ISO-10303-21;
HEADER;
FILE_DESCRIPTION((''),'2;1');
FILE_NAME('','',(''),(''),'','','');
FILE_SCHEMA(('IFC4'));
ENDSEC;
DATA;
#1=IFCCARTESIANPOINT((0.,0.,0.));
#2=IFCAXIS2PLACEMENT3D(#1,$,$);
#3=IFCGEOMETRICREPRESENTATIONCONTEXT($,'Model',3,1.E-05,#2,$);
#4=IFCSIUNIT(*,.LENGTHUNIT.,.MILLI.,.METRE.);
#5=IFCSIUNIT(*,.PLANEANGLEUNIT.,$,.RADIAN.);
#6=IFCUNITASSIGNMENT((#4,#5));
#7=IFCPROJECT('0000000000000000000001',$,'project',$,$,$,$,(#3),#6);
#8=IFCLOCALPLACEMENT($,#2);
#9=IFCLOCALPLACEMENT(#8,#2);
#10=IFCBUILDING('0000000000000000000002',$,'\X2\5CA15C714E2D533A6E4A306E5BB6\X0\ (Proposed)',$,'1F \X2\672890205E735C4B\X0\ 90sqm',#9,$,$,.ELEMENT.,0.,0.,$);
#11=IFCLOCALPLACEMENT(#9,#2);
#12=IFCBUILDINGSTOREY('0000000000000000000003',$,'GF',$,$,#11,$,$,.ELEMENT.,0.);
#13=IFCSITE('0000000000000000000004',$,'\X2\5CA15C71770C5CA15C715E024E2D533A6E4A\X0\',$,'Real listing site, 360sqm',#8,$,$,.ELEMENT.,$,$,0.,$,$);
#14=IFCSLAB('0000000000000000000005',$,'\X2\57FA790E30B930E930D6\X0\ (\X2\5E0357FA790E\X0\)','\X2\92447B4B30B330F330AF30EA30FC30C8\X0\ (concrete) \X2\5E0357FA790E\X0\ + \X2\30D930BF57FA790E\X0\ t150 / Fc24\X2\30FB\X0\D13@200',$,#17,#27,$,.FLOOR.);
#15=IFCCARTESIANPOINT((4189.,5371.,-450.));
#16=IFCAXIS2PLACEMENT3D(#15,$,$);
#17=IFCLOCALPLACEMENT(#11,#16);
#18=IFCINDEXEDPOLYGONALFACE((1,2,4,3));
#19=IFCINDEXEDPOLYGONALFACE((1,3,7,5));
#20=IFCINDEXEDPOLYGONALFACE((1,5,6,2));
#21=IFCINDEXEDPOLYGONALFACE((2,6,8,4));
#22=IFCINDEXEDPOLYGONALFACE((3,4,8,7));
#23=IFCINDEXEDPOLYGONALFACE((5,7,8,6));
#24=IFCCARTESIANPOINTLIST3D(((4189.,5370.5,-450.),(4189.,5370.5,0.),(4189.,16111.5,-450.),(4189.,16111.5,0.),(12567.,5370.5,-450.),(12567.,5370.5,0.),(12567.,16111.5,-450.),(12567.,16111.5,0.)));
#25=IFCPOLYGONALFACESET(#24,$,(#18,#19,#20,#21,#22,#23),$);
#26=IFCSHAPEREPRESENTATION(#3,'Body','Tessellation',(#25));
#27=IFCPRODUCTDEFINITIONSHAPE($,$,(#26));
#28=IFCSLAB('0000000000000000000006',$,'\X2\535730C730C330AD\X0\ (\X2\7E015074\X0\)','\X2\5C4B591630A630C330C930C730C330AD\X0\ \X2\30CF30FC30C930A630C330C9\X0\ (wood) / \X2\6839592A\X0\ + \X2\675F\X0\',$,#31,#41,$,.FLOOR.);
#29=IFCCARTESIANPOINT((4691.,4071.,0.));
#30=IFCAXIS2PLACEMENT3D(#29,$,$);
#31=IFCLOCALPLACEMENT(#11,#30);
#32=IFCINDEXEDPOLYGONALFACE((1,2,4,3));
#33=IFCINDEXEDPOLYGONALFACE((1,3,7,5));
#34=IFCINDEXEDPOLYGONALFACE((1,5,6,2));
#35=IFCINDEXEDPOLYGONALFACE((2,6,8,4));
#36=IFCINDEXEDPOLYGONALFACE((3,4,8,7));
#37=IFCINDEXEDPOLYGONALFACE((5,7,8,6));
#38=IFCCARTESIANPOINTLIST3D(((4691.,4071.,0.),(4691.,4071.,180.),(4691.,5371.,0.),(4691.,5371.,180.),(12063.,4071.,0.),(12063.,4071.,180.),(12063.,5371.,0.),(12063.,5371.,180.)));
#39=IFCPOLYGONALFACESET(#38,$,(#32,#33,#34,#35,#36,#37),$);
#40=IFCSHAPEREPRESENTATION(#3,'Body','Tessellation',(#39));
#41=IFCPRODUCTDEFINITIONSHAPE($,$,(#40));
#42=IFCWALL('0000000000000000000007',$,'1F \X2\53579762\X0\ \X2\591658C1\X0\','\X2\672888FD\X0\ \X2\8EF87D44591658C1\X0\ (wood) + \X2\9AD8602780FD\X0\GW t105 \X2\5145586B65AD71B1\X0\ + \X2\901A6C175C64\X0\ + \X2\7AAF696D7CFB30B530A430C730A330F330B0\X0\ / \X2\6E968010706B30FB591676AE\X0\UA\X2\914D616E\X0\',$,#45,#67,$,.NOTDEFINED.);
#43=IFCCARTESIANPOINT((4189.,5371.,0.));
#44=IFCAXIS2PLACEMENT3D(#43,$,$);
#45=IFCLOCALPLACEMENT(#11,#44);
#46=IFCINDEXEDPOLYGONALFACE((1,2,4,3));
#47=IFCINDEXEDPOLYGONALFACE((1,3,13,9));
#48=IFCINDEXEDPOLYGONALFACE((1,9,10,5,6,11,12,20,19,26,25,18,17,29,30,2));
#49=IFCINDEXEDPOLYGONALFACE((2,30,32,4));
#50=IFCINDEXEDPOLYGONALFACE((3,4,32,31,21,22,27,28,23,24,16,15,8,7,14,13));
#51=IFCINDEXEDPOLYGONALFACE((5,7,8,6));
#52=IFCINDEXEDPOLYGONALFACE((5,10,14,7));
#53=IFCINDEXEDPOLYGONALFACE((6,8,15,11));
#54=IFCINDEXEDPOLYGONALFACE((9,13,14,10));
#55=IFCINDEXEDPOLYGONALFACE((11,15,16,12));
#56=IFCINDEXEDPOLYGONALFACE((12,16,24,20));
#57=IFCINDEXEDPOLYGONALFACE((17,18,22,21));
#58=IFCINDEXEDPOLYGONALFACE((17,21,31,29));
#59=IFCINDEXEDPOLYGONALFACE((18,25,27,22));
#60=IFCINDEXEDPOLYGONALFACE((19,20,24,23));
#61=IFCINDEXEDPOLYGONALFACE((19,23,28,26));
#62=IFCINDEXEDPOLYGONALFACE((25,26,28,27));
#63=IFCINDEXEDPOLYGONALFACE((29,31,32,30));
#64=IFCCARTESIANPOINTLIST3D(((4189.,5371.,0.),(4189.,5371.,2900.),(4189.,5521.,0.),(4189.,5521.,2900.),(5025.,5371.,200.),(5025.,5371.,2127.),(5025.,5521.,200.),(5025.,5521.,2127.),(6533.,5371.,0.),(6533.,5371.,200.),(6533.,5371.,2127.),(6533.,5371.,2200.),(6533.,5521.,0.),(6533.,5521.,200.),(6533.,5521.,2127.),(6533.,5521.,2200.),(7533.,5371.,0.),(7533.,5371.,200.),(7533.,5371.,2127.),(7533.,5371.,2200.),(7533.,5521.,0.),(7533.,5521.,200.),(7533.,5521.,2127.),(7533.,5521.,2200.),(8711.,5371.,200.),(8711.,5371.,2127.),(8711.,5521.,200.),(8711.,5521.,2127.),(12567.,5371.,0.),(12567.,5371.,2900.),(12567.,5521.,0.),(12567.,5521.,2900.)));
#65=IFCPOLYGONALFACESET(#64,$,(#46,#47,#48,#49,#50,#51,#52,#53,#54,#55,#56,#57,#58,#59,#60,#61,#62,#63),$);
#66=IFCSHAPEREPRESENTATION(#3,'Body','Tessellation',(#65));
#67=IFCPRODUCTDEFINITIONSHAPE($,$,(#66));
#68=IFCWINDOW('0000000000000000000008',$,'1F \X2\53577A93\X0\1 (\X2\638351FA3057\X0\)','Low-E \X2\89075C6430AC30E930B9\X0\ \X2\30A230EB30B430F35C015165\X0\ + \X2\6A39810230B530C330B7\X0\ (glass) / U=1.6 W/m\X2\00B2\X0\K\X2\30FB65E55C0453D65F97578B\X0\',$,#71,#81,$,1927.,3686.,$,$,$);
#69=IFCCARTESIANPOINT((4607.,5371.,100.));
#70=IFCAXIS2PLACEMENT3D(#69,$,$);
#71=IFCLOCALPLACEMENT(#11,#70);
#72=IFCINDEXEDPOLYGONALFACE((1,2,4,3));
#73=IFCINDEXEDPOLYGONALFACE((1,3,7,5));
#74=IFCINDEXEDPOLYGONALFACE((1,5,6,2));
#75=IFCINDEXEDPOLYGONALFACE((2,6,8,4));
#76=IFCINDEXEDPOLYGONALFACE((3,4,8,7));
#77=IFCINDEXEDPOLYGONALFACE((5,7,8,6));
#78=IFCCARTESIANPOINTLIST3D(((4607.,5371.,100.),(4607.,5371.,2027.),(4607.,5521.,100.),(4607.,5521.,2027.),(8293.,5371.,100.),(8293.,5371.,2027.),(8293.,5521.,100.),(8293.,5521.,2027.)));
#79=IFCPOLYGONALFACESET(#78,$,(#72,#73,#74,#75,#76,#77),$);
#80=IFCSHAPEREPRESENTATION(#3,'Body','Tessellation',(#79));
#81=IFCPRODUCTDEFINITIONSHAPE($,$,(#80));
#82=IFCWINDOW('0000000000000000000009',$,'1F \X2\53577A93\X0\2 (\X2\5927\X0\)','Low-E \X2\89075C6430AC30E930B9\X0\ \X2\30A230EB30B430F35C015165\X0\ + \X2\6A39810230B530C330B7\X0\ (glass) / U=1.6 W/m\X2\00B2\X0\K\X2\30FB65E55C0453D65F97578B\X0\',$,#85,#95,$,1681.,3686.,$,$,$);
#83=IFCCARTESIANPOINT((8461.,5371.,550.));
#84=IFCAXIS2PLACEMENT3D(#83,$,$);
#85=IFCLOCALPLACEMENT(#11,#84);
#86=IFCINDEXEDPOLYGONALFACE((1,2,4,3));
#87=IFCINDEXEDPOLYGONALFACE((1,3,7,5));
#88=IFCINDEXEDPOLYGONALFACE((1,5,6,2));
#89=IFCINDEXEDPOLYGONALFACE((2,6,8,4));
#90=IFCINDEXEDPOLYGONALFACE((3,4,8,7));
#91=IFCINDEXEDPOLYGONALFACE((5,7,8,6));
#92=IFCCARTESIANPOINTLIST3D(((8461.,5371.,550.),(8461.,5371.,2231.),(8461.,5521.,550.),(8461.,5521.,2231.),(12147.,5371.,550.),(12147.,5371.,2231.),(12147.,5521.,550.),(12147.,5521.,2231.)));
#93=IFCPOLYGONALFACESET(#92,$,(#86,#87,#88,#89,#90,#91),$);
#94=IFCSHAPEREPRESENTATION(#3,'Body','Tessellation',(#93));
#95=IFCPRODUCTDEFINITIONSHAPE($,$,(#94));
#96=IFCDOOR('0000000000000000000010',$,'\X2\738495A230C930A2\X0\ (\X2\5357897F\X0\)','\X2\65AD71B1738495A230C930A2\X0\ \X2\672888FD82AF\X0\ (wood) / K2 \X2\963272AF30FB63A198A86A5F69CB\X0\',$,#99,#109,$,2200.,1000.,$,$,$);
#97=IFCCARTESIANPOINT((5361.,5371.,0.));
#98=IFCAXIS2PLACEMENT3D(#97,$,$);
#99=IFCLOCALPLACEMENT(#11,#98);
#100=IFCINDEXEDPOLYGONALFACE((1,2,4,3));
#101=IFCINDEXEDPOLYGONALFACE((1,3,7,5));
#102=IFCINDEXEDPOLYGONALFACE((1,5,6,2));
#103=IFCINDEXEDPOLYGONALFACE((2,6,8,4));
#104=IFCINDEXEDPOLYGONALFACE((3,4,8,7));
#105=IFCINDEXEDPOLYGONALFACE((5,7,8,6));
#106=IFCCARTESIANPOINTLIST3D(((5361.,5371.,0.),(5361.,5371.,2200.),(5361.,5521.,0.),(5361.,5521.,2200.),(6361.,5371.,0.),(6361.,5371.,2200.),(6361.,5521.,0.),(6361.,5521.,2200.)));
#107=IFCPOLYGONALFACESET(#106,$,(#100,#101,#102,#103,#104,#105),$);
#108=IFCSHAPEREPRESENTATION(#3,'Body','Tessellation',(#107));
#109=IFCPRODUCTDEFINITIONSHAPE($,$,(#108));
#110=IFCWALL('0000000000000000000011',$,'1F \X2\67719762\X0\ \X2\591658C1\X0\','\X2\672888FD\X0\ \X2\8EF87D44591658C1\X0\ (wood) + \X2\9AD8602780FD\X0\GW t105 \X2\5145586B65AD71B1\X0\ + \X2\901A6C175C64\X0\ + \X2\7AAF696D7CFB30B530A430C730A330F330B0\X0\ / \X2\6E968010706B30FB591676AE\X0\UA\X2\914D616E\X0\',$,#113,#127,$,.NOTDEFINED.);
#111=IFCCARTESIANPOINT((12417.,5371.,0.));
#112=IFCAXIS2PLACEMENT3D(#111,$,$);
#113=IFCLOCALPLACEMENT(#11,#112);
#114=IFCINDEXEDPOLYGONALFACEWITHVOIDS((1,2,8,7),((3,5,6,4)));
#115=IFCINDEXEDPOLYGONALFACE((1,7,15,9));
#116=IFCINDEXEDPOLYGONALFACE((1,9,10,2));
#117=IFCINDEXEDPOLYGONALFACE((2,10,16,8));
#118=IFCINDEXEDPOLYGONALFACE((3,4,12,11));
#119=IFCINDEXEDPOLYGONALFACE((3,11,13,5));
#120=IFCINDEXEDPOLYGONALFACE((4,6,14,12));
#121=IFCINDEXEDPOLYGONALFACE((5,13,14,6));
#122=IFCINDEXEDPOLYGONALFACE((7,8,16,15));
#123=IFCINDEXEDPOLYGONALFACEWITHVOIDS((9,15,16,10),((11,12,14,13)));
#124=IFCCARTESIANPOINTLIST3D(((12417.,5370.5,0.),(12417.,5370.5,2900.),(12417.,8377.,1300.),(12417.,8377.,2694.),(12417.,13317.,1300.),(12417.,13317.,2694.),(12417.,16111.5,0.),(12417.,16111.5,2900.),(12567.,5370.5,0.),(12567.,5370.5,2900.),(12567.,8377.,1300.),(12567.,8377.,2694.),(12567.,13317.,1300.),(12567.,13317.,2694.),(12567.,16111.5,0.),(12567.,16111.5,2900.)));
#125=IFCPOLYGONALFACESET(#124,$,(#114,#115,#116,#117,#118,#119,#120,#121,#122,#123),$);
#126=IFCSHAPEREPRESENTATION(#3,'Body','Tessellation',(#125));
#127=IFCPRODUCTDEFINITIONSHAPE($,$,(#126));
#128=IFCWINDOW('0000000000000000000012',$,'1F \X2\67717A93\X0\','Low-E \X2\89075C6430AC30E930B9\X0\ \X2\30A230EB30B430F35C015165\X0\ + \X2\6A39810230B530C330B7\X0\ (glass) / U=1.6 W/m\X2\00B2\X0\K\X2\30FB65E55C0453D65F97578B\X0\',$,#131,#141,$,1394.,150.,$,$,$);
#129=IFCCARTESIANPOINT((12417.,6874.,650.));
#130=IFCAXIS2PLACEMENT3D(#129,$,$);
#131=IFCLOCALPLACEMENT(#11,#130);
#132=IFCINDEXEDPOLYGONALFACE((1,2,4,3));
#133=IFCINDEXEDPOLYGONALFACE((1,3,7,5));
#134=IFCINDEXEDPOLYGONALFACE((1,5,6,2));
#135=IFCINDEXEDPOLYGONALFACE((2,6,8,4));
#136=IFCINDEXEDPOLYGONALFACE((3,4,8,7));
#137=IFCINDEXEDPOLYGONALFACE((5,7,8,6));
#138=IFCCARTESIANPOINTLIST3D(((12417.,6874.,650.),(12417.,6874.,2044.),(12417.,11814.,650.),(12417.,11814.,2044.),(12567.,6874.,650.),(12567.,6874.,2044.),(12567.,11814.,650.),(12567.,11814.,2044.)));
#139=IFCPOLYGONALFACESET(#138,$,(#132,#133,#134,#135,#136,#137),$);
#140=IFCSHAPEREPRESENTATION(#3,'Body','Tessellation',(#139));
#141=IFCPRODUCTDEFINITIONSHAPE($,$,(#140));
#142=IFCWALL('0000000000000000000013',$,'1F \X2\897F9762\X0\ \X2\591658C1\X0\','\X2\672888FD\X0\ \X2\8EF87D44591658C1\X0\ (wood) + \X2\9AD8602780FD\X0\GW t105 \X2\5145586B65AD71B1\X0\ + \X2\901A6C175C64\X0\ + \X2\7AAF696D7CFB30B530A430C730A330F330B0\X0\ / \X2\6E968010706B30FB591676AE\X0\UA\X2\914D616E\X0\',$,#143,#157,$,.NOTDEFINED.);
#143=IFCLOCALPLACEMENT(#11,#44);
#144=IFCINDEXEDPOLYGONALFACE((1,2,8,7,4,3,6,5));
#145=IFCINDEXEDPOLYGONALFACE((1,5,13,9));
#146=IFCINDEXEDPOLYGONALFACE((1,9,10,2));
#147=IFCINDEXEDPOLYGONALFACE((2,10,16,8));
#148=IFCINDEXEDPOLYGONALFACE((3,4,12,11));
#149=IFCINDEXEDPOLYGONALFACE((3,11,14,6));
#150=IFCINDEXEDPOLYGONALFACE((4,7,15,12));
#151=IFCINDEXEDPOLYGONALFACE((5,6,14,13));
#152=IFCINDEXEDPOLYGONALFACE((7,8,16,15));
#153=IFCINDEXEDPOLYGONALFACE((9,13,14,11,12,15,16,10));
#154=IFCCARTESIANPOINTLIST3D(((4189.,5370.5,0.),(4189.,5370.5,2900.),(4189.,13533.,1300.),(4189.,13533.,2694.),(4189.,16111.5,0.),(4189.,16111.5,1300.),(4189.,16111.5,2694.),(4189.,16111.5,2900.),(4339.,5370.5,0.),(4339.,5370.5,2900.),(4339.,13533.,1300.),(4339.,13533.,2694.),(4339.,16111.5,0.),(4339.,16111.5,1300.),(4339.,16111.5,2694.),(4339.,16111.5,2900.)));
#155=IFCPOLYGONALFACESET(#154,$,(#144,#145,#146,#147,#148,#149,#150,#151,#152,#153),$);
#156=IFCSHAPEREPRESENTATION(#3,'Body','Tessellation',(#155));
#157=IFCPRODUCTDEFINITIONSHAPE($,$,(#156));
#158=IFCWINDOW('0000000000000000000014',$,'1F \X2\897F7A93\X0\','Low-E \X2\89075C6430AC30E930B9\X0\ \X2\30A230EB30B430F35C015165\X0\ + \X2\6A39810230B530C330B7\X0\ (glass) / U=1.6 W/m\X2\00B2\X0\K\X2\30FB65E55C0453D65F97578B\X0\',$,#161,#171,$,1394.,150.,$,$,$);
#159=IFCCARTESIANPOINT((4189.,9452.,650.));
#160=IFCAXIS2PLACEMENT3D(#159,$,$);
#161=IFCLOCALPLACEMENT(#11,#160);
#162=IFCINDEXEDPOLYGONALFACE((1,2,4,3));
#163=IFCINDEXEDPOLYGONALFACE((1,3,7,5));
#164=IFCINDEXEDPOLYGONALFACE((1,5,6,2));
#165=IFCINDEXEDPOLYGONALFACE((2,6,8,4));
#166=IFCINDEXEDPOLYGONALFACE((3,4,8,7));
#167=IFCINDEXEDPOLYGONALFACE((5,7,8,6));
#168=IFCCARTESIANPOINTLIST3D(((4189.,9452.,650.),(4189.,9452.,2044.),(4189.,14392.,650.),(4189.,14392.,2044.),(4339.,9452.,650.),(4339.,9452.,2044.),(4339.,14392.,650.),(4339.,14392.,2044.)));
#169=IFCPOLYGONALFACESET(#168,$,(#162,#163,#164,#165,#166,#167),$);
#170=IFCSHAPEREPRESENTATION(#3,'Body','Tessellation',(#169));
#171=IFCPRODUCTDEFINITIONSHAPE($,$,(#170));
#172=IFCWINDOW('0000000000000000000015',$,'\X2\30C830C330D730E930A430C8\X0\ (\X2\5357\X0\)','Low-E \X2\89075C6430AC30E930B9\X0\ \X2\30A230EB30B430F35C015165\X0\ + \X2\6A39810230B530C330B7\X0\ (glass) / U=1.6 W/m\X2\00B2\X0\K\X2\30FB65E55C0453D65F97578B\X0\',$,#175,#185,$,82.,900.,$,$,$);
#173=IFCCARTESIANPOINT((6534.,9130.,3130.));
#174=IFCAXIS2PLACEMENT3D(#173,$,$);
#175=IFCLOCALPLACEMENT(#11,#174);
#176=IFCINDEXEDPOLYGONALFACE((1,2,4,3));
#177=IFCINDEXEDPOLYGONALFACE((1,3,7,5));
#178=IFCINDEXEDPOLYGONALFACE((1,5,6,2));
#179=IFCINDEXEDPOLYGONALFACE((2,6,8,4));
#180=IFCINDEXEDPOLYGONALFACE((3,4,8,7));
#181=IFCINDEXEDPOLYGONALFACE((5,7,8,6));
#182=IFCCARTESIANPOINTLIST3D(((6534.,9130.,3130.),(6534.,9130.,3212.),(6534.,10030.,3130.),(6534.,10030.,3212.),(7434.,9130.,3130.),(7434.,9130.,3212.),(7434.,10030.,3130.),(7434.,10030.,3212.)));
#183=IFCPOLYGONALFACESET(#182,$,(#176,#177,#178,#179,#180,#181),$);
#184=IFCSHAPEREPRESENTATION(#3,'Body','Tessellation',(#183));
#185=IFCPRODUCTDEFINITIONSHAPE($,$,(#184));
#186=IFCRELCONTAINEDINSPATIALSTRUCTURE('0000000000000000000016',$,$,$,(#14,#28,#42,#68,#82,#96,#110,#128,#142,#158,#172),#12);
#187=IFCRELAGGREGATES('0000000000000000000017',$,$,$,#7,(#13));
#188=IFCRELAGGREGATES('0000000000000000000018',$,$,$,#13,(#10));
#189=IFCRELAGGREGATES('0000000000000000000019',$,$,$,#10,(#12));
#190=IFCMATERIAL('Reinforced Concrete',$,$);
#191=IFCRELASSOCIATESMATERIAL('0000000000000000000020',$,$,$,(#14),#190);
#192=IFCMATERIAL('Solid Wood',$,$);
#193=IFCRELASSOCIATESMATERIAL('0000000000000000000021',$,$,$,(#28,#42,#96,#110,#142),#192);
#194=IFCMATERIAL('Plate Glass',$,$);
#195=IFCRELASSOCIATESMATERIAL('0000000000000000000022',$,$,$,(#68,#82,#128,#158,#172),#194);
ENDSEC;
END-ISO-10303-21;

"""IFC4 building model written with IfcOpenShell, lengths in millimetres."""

from ifc_helpers import new_model, si_unit, frame, frame_2d, origin, place, context, project, spatial, rectangle, extrude, material, element, fill, save


model = new_model("IFC4")

# Units and contexts
model_context = context("Model", 3, precision=1e-05, world=origin())
ifc_project = project(units=[si_unit("LENGTHUNIT", "METRE", prefix="MILLI"), si_unit("PLANEANGLEUNIT", "RADIAN")], contexts=[model_context])

# Site, building, storey
site_placement = place(None, origin())
site = spatial("IfcSite", under=ifc_project, at=site_placement, Name="岡山県岡山市中区湊", ObjectType="Real listing site, 360sqm", CompositionType="ELEMENT", RefElevation=0.0)
building_placement = place(site_placement, origin())
building = spatial("IfcBuilding", under=site, at=building_placement, Name="岡山中区湊の家 (Proposed)", ObjectType="1F 木造平屋 90sqm", CompositionType="ELEMENT", ElevationOfRefHeight=0.0, ElevationOfTerrain=0.0)
storey_placement = place(building_placement, origin())
storey = spatial("IfcBuildingStorey", under=building, at=storey_placement, Name="GF", CompositionType="ELEMENT", Elevation=0.0)

# Slabs
ifc_material_1 = material(Name="Reinforced Concrete")
slab_1_placement = place(storey_placement, frame((4189.0, 5371.0, -450.0)))
element("IfcSlab", 1, at=slab_1_placement, inside=storey, material=ifc_material_1, Name="基礎スラブ (布基礎)", Description="鉄筋コンクリート (concrete) 布基礎 + ベタ基礎 t150 / Fc24・D13@200", PredefinedType="FLOOR", context=model_context, shape_type="SweptSolid", body=[
    extrude(rectangle(XDim=8378.0, YDim=10741.0, at=frame_2d((4189.0, 5370.0))), frame((4189.0, 5371.0, -450.0)), (0.0, 0.0, 1.0), 450.0),
])
ifc_material_2 = material(Name="Solid Wood")
slab_2_placement = place(storey_placement, frame((4691.0, 4071.0, 0.0)))
element("IfcSlab", 2, at=slab_2_placement, inside=storey, material=ifc_material_2, Name="南デッキ (縁側)", Description="屋外ウッドデッキ ハードウッド (wood) / 根太 + 束", PredefinedType="FLOOR", context=model_context, shape_type="SweptSolid", body=[
    extrude(rectangle(XDim=7372.0, YDim=1300.0, at=frame_2d((3686.0, 650.0))), frame((4691.0, 4071.0, 0.0)), (0.0, 0.0, 1.0), 180.0),
])

# Wall, openings, windows, door
wall_1_placement = place(storey_placement, frame((4189.0, 5371.0, 0.0)))
wall_1 = element("IfcWall", 3, at=wall_1_placement, inside=storey, material=ifc_material_2, Name="1F 南面 外壁", Description="木製 軸組外壁 (wood) + 高性能GW t105 充填断熱 + 通気層 + 窯業系サイディング / 準耐火・外皮UA配慮", PredefinedType="NOTDEFINED", context=model_context, shape_type="SweptSolid", body=[
    extrude(rectangle(XDim=8378.0, YDim=150.0, at=frame_2d((4189.0, 75.0))), frame((4189.0, 5371.0, 0.0)), (0.0, 0.0, 1.0), 2900.0),
])
opening_1_placement = place(storey_placement, frame((4607.0, 5371.0, 100.0)))
opening_1 = element("IfcOpeningElement", 4, at=opening_1_placement, cuts=wall_1, PredefinedType="NOTDEFINED", context=model_context, shape_type="SweptSolid", body=[
    extrude(rectangle(XDim=3686.0, YDim=150.0, at=frame_2d((1843.0, 75.0))), frame((4607.0, 5371.0, 100.0)), (0.0, 0.0, 1.0), 1927.0),
])
opening_2_placement = place(storey_placement, frame((8461.0, 5371.0, 550.0)))
opening_2 = element("IfcOpeningElement", 5, at=opening_2_placement, cuts=wall_1, PredefinedType="NOTDEFINED", context=model_context, shape_type="SweptSolid", body=[
    extrude(rectangle(XDim=3686.0, YDim=150.0, at=frame_2d((1843.0, 75.0))), frame((8461.0, 5371.0, 550.0)), (0.0, 0.0, 1.0), 1681.0),
])
opening_3_placement = place(storey_placement, frame((5361.0, 5371.0, 0.0)))
opening_3 = element("IfcOpeningElement", 6, at=opening_3_placement, cuts=wall_1, PredefinedType="NOTDEFINED", context=model_context, shape_type="SweptSolid", body=[
    extrude(rectangle(XDim=1000.0, YDim=150.0, at=frame_2d((500.0, 75.0))), frame((5361.0, 5371.0, 0.0)), (0.0, 0.0, 1.0), 2200.0),
])
ifc_material_3 = material(Name="Plate Glass")
window_1_placement = place(storey_placement, frame((4607.0, 5371.0, 100.0)))
window_1 = element("IfcWindow", 7, at=window_1_placement, inside=storey, material=ifc_material_3, Name="1F 南窓1 (掃出し)", Description="Low-E 複層ガラス アルゴン封入 + 樹脂サッシ (glass) / U=1.6 W/m²K・日射取得型", OverallHeight=1927.0, OverallWidth=3686.0, context=model_context, shape_type="SweptSolid", body=[
    extrude(rectangle(XDim=3686.0, YDim=150.0, at=frame_2d((1843.0, 75.0))), frame((4607.0, 5371.0, 100.0)), (0.0, 0.0, 1.0), 1927.0),
])
fill(opening_1, window_1)
window_2_placement = place(storey_placement, frame((8461.0, 5371.0, 550.0)))
window_2 = element("IfcWindow", 8, at=window_2_placement, inside=storey, material=ifc_material_3, Name="1F 南窓2 (大)", Description="Low-E 複層ガラス アルゴン封入 + 樹脂サッシ (glass) / U=1.6 W/m²K・日射取得型", OverallHeight=1681.0, OverallWidth=3686.0, context=model_context, shape_type="SweptSolid", body=[
    extrude(rectangle(XDim=3686.0, YDim=150.0, at=frame_2d((1843.0, 75.0))), frame((8461.0, 5371.0, 550.0)), (0.0, 0.0, 1.0), 1681.0),
])
fill(opening_2, window_2)
door_placement = place(storey_placement, frame((5361.0, 5371.0, 0.0)))
door = element("IfcDoor", 9, at=door_placement, inside=storey, material=ifc_material_2, Name="玄関ドア (南西)", Description="断熱玄関ドア 木製芯 (wood) / K2 防犯・採風機構", OverallHeight=2200.0, OverallWidth=1000.0, context=model_context, shape_type="SweptSolid", body=[
    extrude(rectangle(XDim=1000.0, YDim=150.0, at=frame_2d((500.0, 75.0))), frame((5361.0, 5371.0, 0.0)), (0.0, 0.0, 1.0), 2200.0),
])
fill(opening_3, door)

# Walls, openings, windows
wall_2_placement = place(storey_placement, frame((12417.0, 5371.0, 0.0)))
wall_2 = element("IfcWall", 10, at=wall_2_placement, inside=storey, material=ifc_material_2, Name="1F 東面 外壁", Description="木製 軸組外壁 (wood) + 高性能GW t105 充填断熱 + 通気層 + 窯業系サイディング / 準耐火・外皮UA配慮", PredefinedType="NOTDEFINED", context=model_context, shape_type="SweptSolid", body=[
    extrude(rectangle(XDim=150.0, YDim=10741.0, at=frame_2d((75.0, 5370.0))), frame((12417.0, 5371.0, 0.0)), (0.0, 0.0, 1.0), 2900.0),
])
opening_4_placement = place(storey_placement, frame((12417.0, 6874.0, 650.0)))
opening_4 = element("IfcOpeningElement", 11, at=opening_4_placement, cuts=wall_2, PredefinedType="NOTDEFINED", context=model_context, shape_type="SweptSolid", body=[
    extrude(rectangle(XDim=150.0, YDim=4940.0, at=frame_2d((75.0, 2470.0))), frame((12417.0, 6874.0, 650.0)), (0.0, 0.0, 1.0), 1394.0),
])
window_3_placement = place(storey_placement, frame((12417.0, 6874.0, 650.0)))
window_3 = element("IfcWindow", 12, at=window_3_placement, inside=storey, material=ifc_material_3, Name="1F 東窓", Description="Low-E 複層ガラス アルゴン封入 + 樹脂サッシ (glass) / U=1.6 W/m²K・日射取得型", OverallHeight=1394.0, OverallWidth=150.0, context=model_context, shape_type="SweptSolid", body=[
    extrude(rectangle(XDim=150.0, YDim=4940.0, at=frame_2d((75.0, 2470.0))), frame((12417.0, 6874.0, 650.0)), (0.0, 0.0, 1.0), 1394.0),
])
fill(opening_4, window_3)
wall_3_placement = place(storey_placement, frame((4189.0, 5371.0, 0.0)))
wall_3 = element("IfcWall", 13, at=wall_3_placement, inside=storey, material=ifc_material_2, Name="1F 西面 外壁", Description="木製 軸組外壁 (wood) + 高性能GW t105 充填断熱 + 通気層 + 窯業系サイディング / 準耐火・外皮UA配慮", PredefinedType="NOTDEFINED", context=model_context, shape_type="SweptSolid", body=[
    extrude(rectangle(XDim=150.0, YDim=10741.0, at=frame_2d((75.0, 5370.0))), frame((4189.0, 5371.0, 0.0)), (0.0, 0.0, 1.0), 2900.0),
])
opening_5_placement = place(storey_placement, frame((4189.0, 9452.0, 650.0)))
opening_5 = element("IfcOpeningElement", 14, at=opening_5_placement, cuts=wall_3, PredefinedType="NOTDEFINED", context=model_context, shape_type="SweptSolid", body=[
    extrude(rectangle(XDim=150.0, YDim=4940.0, at=frame_2d((75.0, 2470.0))), frame((4189.0, 9452.0, 650.0)), (0.0, 0.0, 1.0), 1394.0),
])
window_4_placement = place(storey_placement, frame((4189.0, 9452.0, 650.0)))
window_4 = element("IfcWindow", 15, at=window_4_placement, inside=storey, material=ifc_material_3, Name="1F 西窓", Description="Low-E 複層ガラス アルゴン封入 + 樹脂サッシ (glass) / U=1.6 W/m²K・日射取得型", OverallHeight=1394.0, OverallWidth=150.0, context=model_context, shape_type="SweptSolid", body=[
    extrude(rectangle(XDim=150.0, YDim=4940.0, at=frame_2d((75.0, 2470.0))), frame((4189.0, 9452.0, 650.0)), (0.0, 0.0, 1.0), 1394.0),
])
fill(opening_5, window_4)

# Window
window_5_placement = place(storey_placement, frame((6534.0, 9130.0, 3130.0)))
element("IfcWindow", 16, at=window_5_placement, inside=storey, material=ifc_material_3, Name="トップライト (南)", Description="Low-E 複層ガラス アルゴン封入 + 樹脂サッシ (glass) / U=1.6 W/m²K・日射取得型", OverallHeight=82.0, OverallWidth=900.0, context=model_context, shape_type="SweptSolid", body=[
    extrude(rectangle(XDim=900.0, YDim=900.0, at=frame_2d((450.0, 450.0))), frame((6534.0, 9130.0, 3130.0)), (0.0, 0.0, 1.0), 82.0),
])

save(model, "model.ifc")
